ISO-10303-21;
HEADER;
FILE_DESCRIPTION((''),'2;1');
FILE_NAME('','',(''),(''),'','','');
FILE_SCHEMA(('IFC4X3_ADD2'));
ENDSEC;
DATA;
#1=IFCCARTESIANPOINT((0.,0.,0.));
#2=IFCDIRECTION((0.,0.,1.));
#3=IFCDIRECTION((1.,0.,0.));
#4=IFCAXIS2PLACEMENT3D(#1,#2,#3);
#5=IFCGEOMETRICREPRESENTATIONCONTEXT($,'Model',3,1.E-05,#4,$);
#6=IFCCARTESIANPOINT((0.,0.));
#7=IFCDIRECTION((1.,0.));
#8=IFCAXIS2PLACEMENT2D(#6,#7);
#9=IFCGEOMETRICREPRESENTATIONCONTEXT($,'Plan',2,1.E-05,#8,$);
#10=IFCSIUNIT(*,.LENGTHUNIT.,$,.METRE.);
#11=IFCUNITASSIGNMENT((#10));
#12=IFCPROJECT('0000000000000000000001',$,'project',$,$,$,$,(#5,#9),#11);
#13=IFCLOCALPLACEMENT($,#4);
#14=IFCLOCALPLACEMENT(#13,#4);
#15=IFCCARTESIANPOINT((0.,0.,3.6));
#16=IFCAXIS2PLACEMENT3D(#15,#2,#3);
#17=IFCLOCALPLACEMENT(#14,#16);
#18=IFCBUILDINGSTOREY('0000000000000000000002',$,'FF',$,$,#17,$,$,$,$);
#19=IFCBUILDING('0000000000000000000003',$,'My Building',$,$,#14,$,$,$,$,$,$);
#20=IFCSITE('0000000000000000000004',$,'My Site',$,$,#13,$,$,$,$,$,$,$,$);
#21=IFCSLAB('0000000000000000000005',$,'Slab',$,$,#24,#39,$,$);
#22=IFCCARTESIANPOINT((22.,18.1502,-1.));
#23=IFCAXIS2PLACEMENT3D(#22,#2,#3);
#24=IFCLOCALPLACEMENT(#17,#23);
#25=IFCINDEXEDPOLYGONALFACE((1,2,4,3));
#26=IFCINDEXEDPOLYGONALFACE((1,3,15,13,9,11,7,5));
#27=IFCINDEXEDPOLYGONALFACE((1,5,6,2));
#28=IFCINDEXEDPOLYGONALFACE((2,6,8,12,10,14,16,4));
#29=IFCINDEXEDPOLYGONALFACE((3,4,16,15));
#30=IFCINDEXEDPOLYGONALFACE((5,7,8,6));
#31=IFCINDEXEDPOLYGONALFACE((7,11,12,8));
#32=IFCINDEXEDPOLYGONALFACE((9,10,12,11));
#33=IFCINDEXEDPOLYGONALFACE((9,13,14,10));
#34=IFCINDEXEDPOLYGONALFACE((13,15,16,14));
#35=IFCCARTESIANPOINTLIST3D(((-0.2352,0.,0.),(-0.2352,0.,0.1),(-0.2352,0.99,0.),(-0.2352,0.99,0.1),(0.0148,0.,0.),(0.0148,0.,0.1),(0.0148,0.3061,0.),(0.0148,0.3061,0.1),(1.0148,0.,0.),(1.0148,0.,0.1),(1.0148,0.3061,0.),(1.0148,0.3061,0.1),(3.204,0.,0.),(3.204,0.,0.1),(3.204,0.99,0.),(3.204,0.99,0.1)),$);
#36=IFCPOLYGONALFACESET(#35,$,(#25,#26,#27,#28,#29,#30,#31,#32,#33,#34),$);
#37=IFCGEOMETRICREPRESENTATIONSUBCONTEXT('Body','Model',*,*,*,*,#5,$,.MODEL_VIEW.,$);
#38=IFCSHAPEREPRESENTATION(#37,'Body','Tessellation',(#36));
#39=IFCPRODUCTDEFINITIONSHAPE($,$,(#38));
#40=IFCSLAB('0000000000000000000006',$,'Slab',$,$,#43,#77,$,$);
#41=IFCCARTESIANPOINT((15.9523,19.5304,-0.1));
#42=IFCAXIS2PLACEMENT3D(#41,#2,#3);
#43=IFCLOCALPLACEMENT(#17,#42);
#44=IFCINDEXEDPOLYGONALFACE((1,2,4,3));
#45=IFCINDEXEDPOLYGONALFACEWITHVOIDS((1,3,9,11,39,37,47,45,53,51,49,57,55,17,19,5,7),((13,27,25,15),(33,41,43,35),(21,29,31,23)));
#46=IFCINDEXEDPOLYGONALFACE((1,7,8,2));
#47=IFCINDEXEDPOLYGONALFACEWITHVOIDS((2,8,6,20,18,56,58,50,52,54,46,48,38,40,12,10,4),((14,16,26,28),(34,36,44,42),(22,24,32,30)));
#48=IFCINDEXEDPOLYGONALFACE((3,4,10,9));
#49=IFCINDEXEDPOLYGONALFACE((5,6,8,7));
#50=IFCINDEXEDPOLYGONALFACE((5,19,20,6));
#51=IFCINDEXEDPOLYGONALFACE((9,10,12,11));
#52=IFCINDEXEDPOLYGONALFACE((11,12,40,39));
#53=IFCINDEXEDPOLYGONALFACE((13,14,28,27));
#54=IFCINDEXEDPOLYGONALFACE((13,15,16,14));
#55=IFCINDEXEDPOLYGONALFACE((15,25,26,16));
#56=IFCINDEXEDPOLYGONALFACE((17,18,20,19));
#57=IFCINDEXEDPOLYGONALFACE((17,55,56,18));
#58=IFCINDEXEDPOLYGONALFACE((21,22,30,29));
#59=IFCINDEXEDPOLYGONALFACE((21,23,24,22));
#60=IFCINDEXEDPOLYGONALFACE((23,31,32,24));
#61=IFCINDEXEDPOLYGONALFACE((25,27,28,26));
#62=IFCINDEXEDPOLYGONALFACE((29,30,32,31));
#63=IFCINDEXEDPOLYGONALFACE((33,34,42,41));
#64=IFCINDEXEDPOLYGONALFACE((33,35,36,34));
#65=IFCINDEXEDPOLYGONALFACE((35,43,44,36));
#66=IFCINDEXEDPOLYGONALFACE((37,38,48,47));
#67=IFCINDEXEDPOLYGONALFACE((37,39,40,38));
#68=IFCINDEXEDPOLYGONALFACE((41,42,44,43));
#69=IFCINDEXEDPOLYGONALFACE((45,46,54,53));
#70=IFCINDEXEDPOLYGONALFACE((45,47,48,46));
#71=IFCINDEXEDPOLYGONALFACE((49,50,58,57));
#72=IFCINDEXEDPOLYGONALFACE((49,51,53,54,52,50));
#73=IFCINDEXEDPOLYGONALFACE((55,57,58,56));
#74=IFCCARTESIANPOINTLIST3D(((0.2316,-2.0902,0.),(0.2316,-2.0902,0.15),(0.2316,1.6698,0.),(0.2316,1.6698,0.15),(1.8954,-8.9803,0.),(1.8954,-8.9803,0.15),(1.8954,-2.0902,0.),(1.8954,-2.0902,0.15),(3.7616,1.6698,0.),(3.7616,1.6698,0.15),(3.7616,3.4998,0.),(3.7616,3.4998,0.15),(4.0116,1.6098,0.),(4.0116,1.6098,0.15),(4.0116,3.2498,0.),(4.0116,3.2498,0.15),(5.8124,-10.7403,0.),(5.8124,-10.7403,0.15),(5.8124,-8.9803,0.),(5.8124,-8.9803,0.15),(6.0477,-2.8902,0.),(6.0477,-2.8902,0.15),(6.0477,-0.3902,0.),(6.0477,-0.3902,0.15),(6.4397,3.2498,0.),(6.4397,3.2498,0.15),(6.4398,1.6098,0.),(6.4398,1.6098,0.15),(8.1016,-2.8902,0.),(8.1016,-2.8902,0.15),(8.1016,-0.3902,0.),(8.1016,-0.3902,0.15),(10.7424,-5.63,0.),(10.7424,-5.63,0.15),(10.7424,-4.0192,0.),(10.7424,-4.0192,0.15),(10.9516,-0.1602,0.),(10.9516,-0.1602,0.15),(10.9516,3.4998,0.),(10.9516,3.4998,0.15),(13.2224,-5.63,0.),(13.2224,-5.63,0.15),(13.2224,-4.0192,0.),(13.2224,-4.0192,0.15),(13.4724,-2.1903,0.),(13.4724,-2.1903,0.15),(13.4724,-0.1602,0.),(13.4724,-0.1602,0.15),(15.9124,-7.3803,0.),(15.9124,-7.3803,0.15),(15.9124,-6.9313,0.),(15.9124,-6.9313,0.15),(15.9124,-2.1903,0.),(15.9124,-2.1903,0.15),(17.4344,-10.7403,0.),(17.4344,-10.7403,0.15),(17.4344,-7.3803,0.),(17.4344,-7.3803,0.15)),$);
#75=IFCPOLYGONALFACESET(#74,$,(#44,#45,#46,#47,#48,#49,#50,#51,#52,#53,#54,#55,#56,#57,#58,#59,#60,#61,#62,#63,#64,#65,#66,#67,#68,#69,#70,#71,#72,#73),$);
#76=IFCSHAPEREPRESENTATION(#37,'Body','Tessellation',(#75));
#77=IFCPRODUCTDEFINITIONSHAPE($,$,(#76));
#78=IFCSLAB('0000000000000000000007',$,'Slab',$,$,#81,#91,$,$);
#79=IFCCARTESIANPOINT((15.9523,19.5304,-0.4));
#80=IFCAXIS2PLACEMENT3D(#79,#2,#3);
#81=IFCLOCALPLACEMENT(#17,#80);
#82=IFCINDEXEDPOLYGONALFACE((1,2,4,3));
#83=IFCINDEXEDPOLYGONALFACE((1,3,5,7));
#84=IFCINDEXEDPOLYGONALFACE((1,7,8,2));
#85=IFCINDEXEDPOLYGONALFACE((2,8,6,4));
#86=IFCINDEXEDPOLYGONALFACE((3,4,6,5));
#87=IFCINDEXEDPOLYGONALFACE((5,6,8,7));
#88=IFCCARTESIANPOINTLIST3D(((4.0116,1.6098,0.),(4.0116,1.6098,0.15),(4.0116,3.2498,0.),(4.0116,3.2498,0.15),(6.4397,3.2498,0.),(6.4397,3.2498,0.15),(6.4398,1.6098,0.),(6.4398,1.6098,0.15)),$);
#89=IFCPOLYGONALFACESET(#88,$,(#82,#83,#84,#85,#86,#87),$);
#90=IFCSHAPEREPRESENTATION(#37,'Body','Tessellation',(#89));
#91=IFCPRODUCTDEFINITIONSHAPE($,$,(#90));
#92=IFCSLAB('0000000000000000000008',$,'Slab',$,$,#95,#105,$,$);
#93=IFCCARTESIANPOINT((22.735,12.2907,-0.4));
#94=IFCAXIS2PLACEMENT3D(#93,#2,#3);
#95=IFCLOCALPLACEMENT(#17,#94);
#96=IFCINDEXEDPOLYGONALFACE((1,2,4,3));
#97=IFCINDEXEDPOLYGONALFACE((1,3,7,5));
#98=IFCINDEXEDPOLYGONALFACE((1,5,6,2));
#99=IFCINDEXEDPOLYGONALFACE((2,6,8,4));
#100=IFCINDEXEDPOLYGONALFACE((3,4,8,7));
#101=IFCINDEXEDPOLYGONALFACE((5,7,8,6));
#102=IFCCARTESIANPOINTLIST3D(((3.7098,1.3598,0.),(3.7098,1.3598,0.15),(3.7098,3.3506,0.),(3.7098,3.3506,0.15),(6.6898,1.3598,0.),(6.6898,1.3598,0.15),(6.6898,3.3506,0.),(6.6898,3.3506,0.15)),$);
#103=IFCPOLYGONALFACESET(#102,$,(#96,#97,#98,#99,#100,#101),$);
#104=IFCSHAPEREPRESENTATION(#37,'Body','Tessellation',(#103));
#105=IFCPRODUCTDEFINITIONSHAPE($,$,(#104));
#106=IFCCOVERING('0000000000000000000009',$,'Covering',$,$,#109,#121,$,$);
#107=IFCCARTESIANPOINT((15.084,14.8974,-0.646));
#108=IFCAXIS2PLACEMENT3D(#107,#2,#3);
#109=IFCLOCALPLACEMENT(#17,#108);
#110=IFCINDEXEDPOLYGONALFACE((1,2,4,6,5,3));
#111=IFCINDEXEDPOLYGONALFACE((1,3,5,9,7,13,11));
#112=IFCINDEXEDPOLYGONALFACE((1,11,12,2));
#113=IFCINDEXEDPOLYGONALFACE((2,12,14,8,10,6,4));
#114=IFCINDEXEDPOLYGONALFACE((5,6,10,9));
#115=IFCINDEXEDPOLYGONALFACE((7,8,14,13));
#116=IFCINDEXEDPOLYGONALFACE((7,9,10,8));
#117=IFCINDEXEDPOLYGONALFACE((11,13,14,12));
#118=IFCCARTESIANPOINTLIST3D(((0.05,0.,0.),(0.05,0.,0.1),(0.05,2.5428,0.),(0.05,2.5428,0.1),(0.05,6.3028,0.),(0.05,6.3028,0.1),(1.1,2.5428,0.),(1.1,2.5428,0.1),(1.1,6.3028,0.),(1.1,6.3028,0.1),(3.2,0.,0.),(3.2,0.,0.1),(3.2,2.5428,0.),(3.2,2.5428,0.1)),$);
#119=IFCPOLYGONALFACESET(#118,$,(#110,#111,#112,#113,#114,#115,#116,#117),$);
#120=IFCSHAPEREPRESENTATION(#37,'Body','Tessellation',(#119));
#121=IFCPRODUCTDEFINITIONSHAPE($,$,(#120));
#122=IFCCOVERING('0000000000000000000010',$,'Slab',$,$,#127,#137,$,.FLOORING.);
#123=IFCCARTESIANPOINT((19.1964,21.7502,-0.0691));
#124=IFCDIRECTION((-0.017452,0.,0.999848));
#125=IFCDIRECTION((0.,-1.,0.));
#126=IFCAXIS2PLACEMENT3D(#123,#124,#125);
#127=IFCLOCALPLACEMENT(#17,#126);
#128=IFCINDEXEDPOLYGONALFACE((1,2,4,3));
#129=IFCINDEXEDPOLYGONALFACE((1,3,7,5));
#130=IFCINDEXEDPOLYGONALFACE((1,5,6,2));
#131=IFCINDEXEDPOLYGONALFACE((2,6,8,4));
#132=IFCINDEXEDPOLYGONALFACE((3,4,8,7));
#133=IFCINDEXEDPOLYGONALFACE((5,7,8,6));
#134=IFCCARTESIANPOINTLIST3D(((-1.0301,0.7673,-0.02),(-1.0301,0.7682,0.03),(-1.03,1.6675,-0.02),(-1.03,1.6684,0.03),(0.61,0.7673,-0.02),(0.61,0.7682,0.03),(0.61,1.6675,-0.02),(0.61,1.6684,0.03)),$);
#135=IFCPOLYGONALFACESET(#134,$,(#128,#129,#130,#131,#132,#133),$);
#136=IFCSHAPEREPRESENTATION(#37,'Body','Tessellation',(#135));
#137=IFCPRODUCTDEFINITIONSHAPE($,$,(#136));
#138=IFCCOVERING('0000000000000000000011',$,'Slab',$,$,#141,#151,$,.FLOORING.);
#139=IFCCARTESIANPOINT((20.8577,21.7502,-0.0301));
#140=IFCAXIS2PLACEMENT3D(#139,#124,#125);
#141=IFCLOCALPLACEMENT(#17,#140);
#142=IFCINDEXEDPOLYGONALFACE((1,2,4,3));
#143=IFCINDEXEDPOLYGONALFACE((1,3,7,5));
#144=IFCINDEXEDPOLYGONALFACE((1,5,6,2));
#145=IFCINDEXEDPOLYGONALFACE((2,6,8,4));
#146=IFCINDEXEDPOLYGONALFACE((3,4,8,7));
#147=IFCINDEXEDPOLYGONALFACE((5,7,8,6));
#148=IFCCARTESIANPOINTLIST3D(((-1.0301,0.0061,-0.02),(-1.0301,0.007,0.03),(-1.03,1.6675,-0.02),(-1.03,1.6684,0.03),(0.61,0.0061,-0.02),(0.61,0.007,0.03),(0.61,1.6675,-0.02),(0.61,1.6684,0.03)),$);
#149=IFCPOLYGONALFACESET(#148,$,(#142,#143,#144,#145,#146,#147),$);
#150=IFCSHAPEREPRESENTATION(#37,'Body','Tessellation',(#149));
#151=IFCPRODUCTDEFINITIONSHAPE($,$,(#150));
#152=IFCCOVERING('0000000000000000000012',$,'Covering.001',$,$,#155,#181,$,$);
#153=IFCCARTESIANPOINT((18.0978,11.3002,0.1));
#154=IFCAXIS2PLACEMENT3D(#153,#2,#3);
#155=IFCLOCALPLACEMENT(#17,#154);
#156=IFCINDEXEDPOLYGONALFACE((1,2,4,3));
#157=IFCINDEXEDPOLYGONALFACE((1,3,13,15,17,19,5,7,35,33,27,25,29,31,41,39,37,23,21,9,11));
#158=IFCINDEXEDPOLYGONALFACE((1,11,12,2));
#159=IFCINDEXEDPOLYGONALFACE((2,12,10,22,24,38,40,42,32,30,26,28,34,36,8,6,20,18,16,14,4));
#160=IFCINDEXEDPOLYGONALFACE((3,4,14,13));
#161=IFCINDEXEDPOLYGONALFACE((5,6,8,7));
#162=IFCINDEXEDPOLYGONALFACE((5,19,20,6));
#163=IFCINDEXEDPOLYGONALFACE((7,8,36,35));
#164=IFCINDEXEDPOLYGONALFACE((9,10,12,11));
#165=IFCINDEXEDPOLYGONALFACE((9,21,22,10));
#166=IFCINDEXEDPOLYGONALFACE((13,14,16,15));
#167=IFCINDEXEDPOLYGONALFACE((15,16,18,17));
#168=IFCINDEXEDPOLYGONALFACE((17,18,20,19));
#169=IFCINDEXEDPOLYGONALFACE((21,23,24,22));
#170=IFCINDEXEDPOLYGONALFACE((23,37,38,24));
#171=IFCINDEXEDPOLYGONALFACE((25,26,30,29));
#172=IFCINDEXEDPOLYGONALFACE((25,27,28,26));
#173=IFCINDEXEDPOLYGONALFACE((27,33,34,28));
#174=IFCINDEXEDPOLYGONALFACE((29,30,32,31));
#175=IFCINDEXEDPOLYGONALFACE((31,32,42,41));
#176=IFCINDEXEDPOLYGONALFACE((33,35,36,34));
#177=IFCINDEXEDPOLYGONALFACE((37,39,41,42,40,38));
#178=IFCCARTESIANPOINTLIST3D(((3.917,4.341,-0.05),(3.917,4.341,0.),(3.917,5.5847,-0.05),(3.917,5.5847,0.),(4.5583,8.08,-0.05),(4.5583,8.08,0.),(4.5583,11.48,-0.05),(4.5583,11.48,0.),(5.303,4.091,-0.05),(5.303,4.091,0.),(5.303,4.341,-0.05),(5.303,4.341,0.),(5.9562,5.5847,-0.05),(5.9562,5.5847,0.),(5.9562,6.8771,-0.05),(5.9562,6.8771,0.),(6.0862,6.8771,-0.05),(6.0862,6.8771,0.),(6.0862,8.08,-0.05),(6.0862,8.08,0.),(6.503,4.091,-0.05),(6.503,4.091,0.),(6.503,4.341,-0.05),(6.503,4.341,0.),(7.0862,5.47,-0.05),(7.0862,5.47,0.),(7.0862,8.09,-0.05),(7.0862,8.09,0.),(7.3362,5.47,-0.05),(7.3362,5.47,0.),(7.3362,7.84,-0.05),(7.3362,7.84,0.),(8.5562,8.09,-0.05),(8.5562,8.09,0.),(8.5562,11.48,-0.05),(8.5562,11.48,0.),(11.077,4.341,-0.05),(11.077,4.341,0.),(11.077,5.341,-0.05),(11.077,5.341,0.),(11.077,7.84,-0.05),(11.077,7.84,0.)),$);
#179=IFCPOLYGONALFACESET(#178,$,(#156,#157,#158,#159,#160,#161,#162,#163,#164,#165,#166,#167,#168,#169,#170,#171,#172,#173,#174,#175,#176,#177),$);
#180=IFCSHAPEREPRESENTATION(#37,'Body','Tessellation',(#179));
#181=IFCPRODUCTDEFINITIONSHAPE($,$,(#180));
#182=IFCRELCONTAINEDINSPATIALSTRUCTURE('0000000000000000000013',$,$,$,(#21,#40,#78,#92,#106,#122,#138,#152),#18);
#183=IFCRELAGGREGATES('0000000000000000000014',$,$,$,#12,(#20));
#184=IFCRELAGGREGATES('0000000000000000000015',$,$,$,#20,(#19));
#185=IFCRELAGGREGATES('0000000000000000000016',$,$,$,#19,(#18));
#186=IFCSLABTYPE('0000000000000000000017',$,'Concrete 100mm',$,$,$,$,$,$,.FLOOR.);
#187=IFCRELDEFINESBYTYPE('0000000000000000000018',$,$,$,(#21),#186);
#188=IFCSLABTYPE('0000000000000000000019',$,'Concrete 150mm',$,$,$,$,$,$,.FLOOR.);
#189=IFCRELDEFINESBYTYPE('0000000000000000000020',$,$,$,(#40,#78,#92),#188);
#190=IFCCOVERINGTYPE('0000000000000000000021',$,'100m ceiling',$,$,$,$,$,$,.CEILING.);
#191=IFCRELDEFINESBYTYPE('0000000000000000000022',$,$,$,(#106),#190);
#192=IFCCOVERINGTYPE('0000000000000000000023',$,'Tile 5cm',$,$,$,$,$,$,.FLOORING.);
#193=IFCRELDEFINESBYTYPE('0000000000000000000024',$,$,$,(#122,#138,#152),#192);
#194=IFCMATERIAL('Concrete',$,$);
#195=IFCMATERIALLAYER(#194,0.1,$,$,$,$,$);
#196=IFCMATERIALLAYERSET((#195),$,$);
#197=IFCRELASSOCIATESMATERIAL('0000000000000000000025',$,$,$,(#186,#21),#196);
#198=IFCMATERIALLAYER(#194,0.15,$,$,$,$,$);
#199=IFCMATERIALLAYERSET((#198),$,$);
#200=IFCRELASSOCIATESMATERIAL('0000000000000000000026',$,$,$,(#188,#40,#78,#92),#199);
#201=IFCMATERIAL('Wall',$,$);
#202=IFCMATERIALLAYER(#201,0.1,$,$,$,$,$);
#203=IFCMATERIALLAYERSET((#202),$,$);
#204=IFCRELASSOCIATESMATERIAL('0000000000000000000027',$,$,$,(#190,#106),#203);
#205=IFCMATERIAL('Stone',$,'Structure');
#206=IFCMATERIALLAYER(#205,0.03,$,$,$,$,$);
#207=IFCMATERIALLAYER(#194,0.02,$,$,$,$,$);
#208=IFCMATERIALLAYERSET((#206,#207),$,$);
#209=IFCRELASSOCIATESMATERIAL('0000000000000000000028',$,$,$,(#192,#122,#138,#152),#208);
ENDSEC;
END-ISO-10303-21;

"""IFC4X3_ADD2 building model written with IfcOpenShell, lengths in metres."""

from ifc_helpers import new_model, si_unit, frame, origin_with_axes, origin_2d_with_axis, place, context, subcontext, project, spatial, line, indexed_curve, outline, extrude, material, layer, layer_set, layer_usage, type_object, element, save


model = new_model("IFC4X3_ADD2")

# Units and contexts
model_context = context("Model", 3, precision=1e-05, world=origin_with_axes())
plan_context = context("Plan", 2, precision=1e-05, world=origin_2d_with_axis())
body_context_1 = subcontext(model_context, "Body", "Model", "MODEL_VIEW")
ifc_project = project(units=[si_unit("LENGTHUNIT", "METRE")], contexts=[model_context, plan_context])

# Site, building, storey
site_placement = place(None, origin_with_axes())
site = spatial("IfcSite", under=ifc_project, at=site_placement, Name="My Site")
building_placement = place(site_placement, origin_with_axes())
building = spatial("IfcBuilding", under=site, at=building_placement, Name="My Building")
storey_placement = place(building_placement, frame((0.0, 0.0, 3.6), z_axis=(0.0, 0.0, 1.0), x_axis=(1.0, 0.0, 0.0)))
storey = spatial("IfcBuildingStorey", under=building, at=storey_placement, Name="FF")

# Slabs
ifc_material_1 = material(Name="Concrete")
ifc_layer_1 = layer(ifc_material_1, 0.1)
ifc_layer_set_1 = layer_set([ifc_layer_1])
ifc_layer_usage_1 = layer_usage(ifc_layer_set_1, "AXIS3", "POSITIVE", 0.0)
slab_type_1 = type_object("IfcSlabType", Name="Concrete 100mm", PredefinedType="FLOOR", material=ifc_layer_set_1)
slab_1_placement = place(storey_placement, frame((22.0, 18.1502, -1.0), z_axis=(0.0, 0.0, 1.0), x_axis=(1.0, 0.0, 0.0)))
element("IfcSlab", 1, at=slab_1_placement, inside=storey, type_object=slab_type_1, material=ifc_layer_usage_1, Name="Slab", context=body_context_1, shape_type="SweptSolid", body=[
    extrude(outline(indexed_curve([(-0.2352, 0.99), (3.204, 0.99), (3.204, 0.0), (1.0148, 0.0), (1.0148, 0.3061), (0.0148, 0.3061), (0.0148, 0.0), (-0.2352, 0.0), (-0.2352, 0.99)])), None, (0.0, 0.0, 1.0), 0.1),
])
ifc_layer_2 = layer(ifc_material_1, 0.15)
ifc_layer_set_2 = layer_set([ifc_layer_2])
ifc_layer_usage_2 = layer_usage(ifc_layer_set_2, "AXIS3", "POSITIVE", 0.0)
slab_type_2 = type_object("IfcSlabType", Name="Concrete 150mm", PredefinedType="FLOOR", material=ifc_layer_set_2)
slab_2_placement = place(storey_placement, frame((15.9523, 19.5304, -0.1), z_axis=(0.0, 0.0, 1.0), x_axis=(1.0, 0.0, 0.0)))
element("IfcSlab", 2, at=slab_2_placement, inside=storey, type_object=slab_type_2, material=ifc_layer_usage_2, Name="Slab", context=body_context_1, shape_type="SweptSolid", body=[
    extrude(outline(indexed_curve([(5.8124, -8.9803), (1.8954, -8.9803), (1.8954, -2.0902), (0.2316, -2.0902), (0.2316, 1.6698), (3.7616, 1.6698), (3.7616, 3.4998), (10.9516, 3.4998), (10.9516, -0.1602), (13.4724, -0.1602), (13.4724, -2.1903), (15.9124, -2.1903), (15.9124, -6.9313), (15.9124, -7.3803), (17.4344, -7.3803), (17.4344, -10.7403), (5.8124, -10.7403), (5.8124, -8.9803)]), holes=[indexed_curve([(13.2224, -4.0192), (10.7424, -4.0192), (10.7424, -5.63), (13.2224, -5.63), (13.2224, -4.0192)]), indexed_curve([(8.1016, -0.3902), (6.0477, -0.3902), (6.0477, -2.8902), (8.1016, -2.8902), (8.1016, -0.3902)]), indexed_curve([(6.4397, 3.2498), (4.0116, 3.2498), (4.0116, 1.6098), (6.4398, 1.6098), (6.4397, 3.2498)])]), None, (0.0, 0.0, 1.0), 0.15),
])
ifc_layer_usage_3 = layer_usage(ifc_layer_set_2, "AXIS3", "POSITIVE", 0.0)
slab_3_placement = place(storey_placement, frame((15.9523, 19.5304, -0.4), z_axis=(0.0, 0.0, 1.0), x_axis=(1.0, 0.0, 0.0)))
element("IfcSlab", 3, at=slab_3_placement, inside=storey, type_object=slab_type_2, material=ifc_layer_usage_3, Name="Slab", context=body_context_1, shape_type="SweptSolid", body=[
    extrude(outline(indexed_curve([(6.4397, 3.2498), (4.0116, 3.2498), (4.0116, 1.6098), (6.4398, 1.6098), (6.4397, 3.2498)])), None, (0.0, 0.0, 1.0), 0.15),
])
ifc_layer_usage_4 = layer_usage(ifc_layer_set_2, "AXIS3", "POSITIVE", 0.0)
slab_4_placement = place(storey_placement, frame((22.735, 12.2907, -0.4), z_axis=(0.0, 0.0, 1.0), x_axis=(1.0, 0.0, 0.0)))
element("IfcSlab", 4, at=slab_4_placement, inside=storey, type_object=slab_type_2, material=ifc_layer_usage_4, Name="Slab", context=body_context_1, shape_type="SweptSolid", body=[
    extrude(outline(indexed_curve([(6.6898, 1.3598), (3.7098, 1.3598), (3.7098, 3.3506), (6.6898, 3.3506), (6.6898, 1.3598)])), None, (0.0, 0.0, 1.0), 0.15),
])

# Coverings
ifc_material_2 = material(Name="Wall")
ifc_layer_3 = layer(ifc_material_2, 0.1)
ifc_layer_set_3 = layer_set([ifc_layer_3])
ifc_layer_usage_5 = layer_usage(ifc_layer_set_3, "AXIS3", "POSITIVE", 0.0)
covering_type_1 = type_object("IfcCoveringType", Name="100m ceiling", PredefinedType="CEILING", material=ifc_layer_set_3)
covering_1_placement = place(storey_placement, frame((15.084, 14.8974, -0.646), z_axis=(0.0, 0.0, 1.0), x_axis=(1.0, 0.0, 0.0)))
element("IfcCovering", 5, at=covering_1_placement, inside=storey, type_object=covering_type_1, material=ifc_layer_usage_5, Name="Covering", context=body_context_1, shape_type="SweptSolid", body=[
    extrude(outline(indexed_curve([(0.05, 6.3028), (0.05, 2.5428), (0.05, 0.0), (3.2, 0.0), (3.2, 2.5428), (1.1, 2.5428), (1.1, 6.3028)], segments=[line(4, 3), line(3, 2), line(2, 1), line(1, 7), line(7, 6), line(6, 5), line(5, 4)], self_intersect=False)), None, (0.0, 0.0, 1.0), 0.1),
])
ifc_material_3 = material(Name="Stone", Category="Structure")
ifc_layer_4 = layer(ifc_material_3, 0.03)
ifc_layer_5 = layer(ifc_material_1, 0.02)
ifc_layer_set_4 = layer_set([ifc_layer_4, ifc_layer_5])
ifc_layer_usage_6 = layer_usage(ifc_layer_set_4, "AXIS3", "POSITIVE", -0.02)
covering_type_2 = type_object("IfcCoveringType", Name="Tile 5cm", PredefinedType="FLOORING", material=ifc_layer_set_4)
covering_2_placement = place(storey_placement, frame((19.1964, 21.7502, -0.0691), z_axis=(-0.017452, 0.0, 0.999848), x_axis=(0.0, -1.0, 0.0)))
element("IfcCovering", 6, at=covering_2_placement, inside=storey, type_object=covering_type_2, material=ifc_layer_usage_6, Name="Slab", PredefinedType="FLOORING", context=body_context_1, shape_type="SweptSolid", body=[
    extrude(outline(indexed_curve([(-1.0301, 0.7677), (0.61, 0.7677), (0.61, 1.6678), (-1.03, 1.6678), (-1.0301, 0.7677)])), frame((0.0, -0.0003, -0.02), z_axis=(0.0, 0.0, 1.0), x_axis=(1.0, 0.0, 0.0)), (0.0, 0.017452, 0.999848), 0.05),
])
ifc_layer_usage_7 = layer_usage(ifc_layer_set_4, "AXIS3", "POSITIVE", -0.02)
covering_3_placement = place(storey_placement, frame((20.8577, 21.7502, -0.0301), z_axis=(-0.017452, 0.0, 0.999848), x_axis=(0.0, -1.0, 0.0)))
element("IfcCovering", 7, at=covering_3_placement, inside=storey, type_object=covering_type_2, material=ifc_layer_usage_7, Name="Slab", PredefinedType="FLOORING", context=body_context_1, shape_type="SweptSolid", body=[
    extrude(outline(indexed_curve([(-1.03, 1.6678), (0.61, 1.6678), (0.61, 0.0065), (-1.0301, 0.0065), (-1.03, 1.6678)])), frame((0.0, -0.0003, -0.02), z_axis=(0.0, 0.0, 1.0), x_axis=(1.0, 0.0, 0.0)), (0.0, 0.017452, 0.999848), 0.05),
])
ifc_layer_usage_8 = layer_usage(ifc_layer_set_4, "AXIS3", "POSITIVE", -0.05)
covering_4_placement = place(storey_placement, frame((18.0978, 11.3002, 0.1), z_axis=(0.0, 0.0, 1.0), x_axis=(1.0, 0.0, 0.0)))
element("IfcCovering", 8, at=covering_4_placement, inside=storey, type_object=covering_type_2, material=ifc_layer_usage_8, Name="Covering.001", context=body_context_1, shape_type="SweptSolid", body=[
    extrude(outline(indexed_curve([(5.9562, 6.8771), (5.9562, 5.5847), (3.917, 5.5847), (3.917, 4.341), (5.303, 4.341), (5.303, 4.091), (6.503, 4.091), (6.503, 4.341), (11.077, 4.341), (11.077, 5.341), (11.077, 7.84), (7.3362, 7.84), (7.3362, 5.47), (7.0862, 5.47), (7.0862, 8.09), (8.5562, 8.09), (8.5562, 11.48), (4.5583, 11.48), (4.5583, 8.08), (6.0862, 8.08), (6.0862, 6.8771), (5.9562, 6.8771)])), frame((0.0, 0.0, -0.05), z_axis=(0.0, 0.0, 1.0), x_axis=(1.0, 0.0, 0.0)), (0.0, 0.0, 1.0), 0.05),
])

save(model, "model.ifc")
